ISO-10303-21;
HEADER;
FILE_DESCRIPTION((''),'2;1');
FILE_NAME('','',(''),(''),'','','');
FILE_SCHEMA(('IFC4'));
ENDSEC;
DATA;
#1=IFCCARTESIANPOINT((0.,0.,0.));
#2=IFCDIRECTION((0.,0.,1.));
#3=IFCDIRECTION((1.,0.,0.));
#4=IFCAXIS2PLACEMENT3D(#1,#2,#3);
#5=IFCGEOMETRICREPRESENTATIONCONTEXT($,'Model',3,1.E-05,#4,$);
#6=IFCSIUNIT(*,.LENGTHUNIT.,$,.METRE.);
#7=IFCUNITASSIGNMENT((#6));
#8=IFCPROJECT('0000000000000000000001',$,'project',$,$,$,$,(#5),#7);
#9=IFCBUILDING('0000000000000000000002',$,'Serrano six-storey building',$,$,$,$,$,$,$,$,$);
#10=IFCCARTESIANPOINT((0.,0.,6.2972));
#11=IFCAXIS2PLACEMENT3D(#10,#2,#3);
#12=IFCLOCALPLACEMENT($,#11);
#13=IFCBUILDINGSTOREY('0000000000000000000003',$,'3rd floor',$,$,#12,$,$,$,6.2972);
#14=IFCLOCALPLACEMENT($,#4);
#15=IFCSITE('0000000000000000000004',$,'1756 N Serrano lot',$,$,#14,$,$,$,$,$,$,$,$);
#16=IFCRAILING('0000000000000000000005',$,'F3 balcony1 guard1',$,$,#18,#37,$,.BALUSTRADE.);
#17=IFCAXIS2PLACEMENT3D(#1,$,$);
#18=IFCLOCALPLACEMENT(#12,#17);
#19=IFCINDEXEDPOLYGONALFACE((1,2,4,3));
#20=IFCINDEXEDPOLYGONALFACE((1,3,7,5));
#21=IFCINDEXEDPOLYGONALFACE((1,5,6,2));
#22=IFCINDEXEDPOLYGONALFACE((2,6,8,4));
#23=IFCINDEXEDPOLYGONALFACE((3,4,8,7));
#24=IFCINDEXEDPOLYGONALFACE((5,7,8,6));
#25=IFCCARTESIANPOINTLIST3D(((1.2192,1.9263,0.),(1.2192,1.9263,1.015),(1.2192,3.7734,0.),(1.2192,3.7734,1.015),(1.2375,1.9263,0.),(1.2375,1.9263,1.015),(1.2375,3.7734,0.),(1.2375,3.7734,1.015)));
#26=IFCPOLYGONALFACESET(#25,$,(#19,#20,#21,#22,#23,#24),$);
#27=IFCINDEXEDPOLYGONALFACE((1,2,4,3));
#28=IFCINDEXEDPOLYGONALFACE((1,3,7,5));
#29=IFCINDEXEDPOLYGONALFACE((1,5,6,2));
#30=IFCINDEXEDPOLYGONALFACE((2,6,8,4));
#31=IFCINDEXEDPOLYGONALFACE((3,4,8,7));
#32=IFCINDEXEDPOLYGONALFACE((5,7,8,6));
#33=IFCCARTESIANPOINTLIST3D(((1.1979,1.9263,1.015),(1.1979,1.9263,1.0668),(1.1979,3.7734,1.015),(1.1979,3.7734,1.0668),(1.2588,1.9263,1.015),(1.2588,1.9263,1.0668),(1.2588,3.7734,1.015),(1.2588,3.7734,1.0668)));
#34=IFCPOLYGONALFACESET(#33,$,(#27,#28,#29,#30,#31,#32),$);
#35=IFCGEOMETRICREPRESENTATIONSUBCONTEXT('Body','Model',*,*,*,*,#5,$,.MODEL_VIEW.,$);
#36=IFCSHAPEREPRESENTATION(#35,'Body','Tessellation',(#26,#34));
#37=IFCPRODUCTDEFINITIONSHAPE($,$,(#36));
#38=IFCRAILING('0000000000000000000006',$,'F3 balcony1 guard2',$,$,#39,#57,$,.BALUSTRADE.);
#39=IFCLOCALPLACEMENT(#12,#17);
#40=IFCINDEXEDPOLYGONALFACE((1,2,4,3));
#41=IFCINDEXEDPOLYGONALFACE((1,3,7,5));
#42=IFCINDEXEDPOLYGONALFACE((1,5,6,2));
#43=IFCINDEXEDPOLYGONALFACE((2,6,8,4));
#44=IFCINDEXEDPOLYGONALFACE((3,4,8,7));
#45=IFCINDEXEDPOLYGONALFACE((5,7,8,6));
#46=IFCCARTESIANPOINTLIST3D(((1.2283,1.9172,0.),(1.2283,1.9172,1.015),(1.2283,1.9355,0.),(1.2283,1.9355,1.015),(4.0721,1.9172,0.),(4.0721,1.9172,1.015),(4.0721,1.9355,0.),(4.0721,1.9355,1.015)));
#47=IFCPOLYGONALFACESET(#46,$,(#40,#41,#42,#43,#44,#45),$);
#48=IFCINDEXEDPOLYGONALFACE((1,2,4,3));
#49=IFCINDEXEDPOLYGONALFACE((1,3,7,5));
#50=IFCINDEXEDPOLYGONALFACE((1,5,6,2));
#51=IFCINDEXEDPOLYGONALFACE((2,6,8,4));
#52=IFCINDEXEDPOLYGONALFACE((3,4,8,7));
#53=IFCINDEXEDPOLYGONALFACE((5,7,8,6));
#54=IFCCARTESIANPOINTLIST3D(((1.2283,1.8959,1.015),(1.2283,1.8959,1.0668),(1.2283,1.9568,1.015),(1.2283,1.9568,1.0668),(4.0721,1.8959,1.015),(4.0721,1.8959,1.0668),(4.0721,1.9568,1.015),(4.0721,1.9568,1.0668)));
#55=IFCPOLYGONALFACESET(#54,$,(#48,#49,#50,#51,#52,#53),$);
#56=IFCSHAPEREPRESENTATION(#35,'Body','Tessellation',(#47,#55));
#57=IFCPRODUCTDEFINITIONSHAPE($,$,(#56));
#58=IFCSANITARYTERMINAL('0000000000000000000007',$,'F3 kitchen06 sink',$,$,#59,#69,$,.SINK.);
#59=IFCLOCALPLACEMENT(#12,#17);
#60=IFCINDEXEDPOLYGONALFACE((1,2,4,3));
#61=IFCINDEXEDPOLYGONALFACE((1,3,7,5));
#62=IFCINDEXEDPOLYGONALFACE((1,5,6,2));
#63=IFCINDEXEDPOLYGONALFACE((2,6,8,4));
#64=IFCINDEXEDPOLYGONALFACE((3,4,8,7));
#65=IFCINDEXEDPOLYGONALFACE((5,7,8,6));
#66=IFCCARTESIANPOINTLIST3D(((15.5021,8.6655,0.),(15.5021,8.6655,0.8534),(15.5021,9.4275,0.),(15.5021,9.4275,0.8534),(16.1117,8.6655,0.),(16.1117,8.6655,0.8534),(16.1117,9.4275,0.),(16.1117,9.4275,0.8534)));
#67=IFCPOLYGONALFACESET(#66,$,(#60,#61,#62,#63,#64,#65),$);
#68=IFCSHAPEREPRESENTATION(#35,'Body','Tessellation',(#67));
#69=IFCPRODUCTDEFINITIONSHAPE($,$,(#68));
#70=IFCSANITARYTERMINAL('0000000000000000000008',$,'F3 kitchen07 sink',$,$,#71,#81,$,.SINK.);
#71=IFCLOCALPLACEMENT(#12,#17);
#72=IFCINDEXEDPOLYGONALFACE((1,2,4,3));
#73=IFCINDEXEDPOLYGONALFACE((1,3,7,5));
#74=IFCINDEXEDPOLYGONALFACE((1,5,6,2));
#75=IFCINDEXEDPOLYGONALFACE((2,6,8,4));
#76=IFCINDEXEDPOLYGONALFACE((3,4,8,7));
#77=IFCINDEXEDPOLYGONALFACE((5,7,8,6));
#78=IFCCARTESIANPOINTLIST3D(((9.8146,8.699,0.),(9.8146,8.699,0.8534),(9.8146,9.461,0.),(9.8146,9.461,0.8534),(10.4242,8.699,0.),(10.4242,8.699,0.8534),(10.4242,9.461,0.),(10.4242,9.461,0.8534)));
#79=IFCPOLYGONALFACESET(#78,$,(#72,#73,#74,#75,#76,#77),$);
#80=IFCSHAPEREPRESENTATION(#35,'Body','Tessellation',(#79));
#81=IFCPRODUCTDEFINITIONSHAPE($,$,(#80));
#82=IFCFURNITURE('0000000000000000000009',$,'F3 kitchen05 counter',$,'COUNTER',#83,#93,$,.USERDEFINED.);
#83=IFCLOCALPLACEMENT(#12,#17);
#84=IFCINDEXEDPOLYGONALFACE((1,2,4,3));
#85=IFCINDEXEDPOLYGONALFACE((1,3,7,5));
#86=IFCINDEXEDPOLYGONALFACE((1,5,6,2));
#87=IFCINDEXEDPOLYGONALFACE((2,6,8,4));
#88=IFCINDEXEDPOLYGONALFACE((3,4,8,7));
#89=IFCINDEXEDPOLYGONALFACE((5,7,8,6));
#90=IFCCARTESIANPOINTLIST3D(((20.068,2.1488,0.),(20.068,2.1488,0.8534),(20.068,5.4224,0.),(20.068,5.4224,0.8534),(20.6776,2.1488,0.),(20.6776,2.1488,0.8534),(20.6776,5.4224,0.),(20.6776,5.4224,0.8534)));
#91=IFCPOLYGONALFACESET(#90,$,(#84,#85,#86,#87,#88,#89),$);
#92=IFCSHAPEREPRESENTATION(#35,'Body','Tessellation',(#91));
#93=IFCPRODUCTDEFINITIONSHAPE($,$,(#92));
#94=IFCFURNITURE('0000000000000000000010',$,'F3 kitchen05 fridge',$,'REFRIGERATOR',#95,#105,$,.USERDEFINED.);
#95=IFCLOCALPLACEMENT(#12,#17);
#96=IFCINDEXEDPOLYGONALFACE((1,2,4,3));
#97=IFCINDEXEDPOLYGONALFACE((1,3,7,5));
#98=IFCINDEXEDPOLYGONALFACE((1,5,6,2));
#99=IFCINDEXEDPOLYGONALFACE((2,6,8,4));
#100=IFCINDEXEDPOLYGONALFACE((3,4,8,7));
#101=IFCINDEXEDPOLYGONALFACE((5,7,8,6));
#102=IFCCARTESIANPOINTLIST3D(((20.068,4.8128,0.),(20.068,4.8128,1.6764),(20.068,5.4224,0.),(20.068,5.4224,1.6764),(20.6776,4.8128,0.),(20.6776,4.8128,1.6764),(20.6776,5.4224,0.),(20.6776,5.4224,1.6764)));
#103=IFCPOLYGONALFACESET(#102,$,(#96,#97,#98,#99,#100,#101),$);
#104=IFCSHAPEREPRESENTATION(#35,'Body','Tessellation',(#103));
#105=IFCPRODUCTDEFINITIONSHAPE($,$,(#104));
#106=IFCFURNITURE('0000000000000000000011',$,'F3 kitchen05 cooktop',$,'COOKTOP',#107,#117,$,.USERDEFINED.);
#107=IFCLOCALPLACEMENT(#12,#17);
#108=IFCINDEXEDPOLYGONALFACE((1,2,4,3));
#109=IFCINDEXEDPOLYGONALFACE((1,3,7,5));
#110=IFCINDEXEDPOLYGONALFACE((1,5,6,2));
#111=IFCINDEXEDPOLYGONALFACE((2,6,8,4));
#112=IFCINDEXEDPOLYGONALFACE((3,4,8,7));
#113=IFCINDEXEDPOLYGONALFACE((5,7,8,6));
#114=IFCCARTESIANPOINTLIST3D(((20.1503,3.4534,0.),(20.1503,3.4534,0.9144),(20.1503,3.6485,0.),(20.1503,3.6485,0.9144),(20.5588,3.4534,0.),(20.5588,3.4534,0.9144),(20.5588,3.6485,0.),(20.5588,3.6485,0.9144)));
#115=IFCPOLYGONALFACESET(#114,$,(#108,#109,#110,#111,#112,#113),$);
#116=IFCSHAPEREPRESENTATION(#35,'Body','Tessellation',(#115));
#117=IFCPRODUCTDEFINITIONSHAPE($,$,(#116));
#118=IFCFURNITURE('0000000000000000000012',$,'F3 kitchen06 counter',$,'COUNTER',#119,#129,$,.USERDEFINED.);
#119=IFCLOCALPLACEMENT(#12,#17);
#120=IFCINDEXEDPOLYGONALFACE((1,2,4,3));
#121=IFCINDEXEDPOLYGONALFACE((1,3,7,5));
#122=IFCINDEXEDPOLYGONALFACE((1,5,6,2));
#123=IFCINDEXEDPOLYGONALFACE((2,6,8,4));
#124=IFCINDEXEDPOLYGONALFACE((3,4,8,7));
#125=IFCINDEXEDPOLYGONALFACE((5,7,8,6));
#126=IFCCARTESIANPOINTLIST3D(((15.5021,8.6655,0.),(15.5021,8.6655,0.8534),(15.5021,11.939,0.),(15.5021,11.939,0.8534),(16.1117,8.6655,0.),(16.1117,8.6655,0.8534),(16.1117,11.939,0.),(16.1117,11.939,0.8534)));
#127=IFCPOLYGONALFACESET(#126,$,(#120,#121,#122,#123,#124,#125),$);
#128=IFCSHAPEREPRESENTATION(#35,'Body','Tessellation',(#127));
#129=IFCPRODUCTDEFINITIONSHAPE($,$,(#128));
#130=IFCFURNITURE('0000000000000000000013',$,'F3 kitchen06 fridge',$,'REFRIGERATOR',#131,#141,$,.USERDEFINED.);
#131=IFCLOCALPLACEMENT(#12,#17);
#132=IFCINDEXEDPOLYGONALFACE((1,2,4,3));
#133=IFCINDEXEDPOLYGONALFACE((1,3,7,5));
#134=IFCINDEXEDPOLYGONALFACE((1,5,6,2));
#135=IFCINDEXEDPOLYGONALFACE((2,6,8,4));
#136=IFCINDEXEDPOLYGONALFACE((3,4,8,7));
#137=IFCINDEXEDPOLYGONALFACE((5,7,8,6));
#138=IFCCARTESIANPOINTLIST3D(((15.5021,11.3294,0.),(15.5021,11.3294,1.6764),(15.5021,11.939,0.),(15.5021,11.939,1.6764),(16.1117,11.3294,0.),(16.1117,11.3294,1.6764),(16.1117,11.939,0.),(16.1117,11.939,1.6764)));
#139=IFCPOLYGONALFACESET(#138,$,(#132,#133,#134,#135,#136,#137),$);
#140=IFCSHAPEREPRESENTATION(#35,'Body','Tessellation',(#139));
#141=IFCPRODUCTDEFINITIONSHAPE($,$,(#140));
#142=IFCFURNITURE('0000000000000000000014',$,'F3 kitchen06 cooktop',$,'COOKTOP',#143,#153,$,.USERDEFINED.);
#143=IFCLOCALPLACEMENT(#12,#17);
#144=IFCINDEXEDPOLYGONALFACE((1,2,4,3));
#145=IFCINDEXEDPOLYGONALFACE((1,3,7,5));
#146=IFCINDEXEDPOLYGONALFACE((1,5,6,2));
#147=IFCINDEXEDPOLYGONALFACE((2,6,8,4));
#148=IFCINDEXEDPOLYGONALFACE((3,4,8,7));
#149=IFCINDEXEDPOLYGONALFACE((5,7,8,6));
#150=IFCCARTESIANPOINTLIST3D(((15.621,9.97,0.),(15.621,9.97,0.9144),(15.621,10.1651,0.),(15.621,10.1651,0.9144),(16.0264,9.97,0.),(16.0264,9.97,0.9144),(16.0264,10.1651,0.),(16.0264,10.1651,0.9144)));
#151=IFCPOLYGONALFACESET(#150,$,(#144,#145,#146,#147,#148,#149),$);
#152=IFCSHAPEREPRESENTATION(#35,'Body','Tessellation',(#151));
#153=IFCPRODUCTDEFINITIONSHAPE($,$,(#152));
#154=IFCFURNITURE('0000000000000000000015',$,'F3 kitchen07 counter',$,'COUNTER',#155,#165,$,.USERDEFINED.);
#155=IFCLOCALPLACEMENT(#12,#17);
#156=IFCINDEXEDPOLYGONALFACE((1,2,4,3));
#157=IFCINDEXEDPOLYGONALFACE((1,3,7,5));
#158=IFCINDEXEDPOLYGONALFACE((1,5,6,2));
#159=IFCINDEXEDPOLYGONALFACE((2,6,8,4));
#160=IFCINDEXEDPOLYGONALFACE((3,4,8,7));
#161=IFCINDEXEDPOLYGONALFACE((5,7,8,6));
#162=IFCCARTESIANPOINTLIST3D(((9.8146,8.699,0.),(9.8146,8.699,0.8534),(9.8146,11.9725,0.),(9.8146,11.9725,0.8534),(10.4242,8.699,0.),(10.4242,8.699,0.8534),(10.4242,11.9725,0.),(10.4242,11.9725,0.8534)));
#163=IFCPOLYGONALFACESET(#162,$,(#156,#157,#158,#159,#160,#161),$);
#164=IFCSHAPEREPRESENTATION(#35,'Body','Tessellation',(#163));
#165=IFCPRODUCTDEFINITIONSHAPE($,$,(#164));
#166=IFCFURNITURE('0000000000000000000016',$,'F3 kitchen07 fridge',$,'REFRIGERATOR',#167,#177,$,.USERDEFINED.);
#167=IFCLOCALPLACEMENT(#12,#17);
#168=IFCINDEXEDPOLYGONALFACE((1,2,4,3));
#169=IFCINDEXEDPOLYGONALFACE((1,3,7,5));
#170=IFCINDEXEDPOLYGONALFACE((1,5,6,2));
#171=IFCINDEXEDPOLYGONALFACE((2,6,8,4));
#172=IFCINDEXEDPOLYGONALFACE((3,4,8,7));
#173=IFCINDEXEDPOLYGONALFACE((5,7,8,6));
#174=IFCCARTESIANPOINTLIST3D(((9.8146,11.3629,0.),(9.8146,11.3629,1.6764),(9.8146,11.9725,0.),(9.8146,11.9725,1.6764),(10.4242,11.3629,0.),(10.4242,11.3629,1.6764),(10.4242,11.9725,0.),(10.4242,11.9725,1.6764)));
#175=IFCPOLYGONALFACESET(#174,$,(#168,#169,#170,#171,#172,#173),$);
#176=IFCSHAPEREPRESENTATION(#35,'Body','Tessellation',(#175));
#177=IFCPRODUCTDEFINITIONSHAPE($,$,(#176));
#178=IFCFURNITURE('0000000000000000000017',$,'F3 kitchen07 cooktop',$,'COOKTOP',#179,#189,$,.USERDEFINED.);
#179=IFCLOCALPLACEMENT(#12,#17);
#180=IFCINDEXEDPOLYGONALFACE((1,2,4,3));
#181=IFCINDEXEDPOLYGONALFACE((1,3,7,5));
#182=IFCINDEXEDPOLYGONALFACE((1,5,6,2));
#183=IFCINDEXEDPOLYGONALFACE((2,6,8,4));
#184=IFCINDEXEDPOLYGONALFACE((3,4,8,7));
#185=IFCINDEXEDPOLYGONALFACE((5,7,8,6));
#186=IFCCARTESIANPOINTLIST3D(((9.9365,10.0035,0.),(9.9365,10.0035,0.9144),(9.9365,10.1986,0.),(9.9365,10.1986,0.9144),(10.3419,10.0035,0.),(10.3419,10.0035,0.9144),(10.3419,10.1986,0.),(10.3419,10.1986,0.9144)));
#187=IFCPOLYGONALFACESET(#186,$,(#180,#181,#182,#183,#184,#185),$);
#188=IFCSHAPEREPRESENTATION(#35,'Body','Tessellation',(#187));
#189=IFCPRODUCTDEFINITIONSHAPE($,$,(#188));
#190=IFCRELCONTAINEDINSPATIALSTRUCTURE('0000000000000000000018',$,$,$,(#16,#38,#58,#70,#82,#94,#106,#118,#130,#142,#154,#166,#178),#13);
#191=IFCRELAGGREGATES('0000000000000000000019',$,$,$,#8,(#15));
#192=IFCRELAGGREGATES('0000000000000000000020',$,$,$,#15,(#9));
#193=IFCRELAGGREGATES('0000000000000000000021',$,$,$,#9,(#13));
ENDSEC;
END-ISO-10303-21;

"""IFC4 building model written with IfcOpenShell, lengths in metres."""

from ifc_helpers import new_model, si_unit, frame, origin_with_axes, place, context, subcontext, project, spatial, polyline, outline, extrude, element, save


model = new_model("IFC4")

# Units and contexts
model_context = context("Model", 3, precision=1e-05, world=origin_with_axes())
body_context = subcontext(model_context, "Body", "Model", "MODEL_VIEW")
ifc_project = project(units=[si_unit("LENGTHUNIT", "METRE")], contexts=[model_context])

# Site, building, storey
site_placement = place(None, origin_with_axes())
site = spatial("IfcSite", under=ifc_project, at=site_placement, Name="1756 N Serrano lot")
building = spatial("IfcBuilding", under=site, Name="Serrano six-storey building")
storey_placement = place(None, frame((0.0, 0.0, 6.2972), z_axis=(0.0, 0.0, 1.0), x_axis=(1.0, 0.0, 0.0)))
storey = spatial("IfcBuildingStorey", under=building, at=storey_placement, Name="3rd floor", Elevation=6.2972)

# Railings
railing_1_placement = place(storey_placement, frame((0.0, 0.0, -6.2972), z_axis=(0.0, 0.0, 1.0), x_axis=(1.0, 0.0, 0.0)))
element("IfcRailing", 1, at=railing_1_placement, inside=storey, Name="F3 balcony1 guard1", PredefinedType="BALUSTRADE", context=body_context, shape_type="SweptSolid", body=[
    extrude(outline(polyline([(1.2192, 3.7734), (1.2375, 3.7734), (1.2375, 1.9263), (1.2192, 1.9263), (1.2192, 3.7734)])), frame((0.0, 0.0, 6.2972)), (0.0, 0.0, 1.0), 1.015),
    extrude(outline(polyline([(1.1979, 3.7734), (1.2588, 3.7734), (1.2588, 1.9263), (1.1979, 1.9263), (1.1979, 3.7734)])), frame((0.0, 0.0, 7.3122)), (0.0, 0.0, 1.0), 0.0518),
])
railing_2_placement = place(storey_placement, frame((0.0, 0.0, -6.2972), z_axis=(0.0, 0.0, 1.0), x_axis=(1.0, 0.0, 0.0)))
element("IfcRailing", 2, at=railing_2_placement, inside=storey, Name="F3 balcony1 guard2", PredefinedType="BALUSTRADE", context=body_context, shape_type="SweptSolid", body=[
    extrude(outline(polyline([(1.2283, 1.9172), (1.2283, 1.9355), (4.0721, 1.9355), (4.0721, 1.9172), (1.2283, 1.9172)])), frame((0.0, 0.0, 6.2972)), (0.0, 0.0, 1.0), 1.015),
    extrude(outline(polyline([(1.2283, 1.8959), (1.2283, 1.9568), (4.0721, 1.9568), (4.0721, 1.8959), (1.2283, 1.8959)])), frame((0.0, 0.0, 7.3122)), (0.0, 0.0, 1.0), 0.0518),
])

# Sanitary terminals
sanitary_terminal_1_placement = place(storey_placement, frame((0.0, 0.0, -6.2972), z_axis=(0.0, 0.0, 1.0), x_axis=(1.0, 0.0, 0.0)))
element("IfcSanitaryTerminal", 3, at=sanitary_terminal_1_placement, inside=storey, Name="F3 kitchen06 sink", PredefinedType="SINK", context=body_context, shape_type="SweptSolid", body=[
    extrude(outline(polyline([(16.1117, 8.6655), (16.1117, 9.4275), (15.5021, 9.4275), (15.5021, 8.6655), (16.1117, 8.6655)])), frame((0.0, 0.0, 6.2972)), (0.0, 0.0, 1.0), 0.8534),
])
sanitary_terminal_2_placement = place(storey_placement, frame((0.0, 0.0, -6.2972), z_axis=(0.0, 0.0, 1.0), x_axis=(1.0, 0.0, 0.0)))
element("IfcSanitaryTerminal", 4, at=sanitary_terminal_2_placement, inside=storey, Name="F3 kitchen07 sink", PredefinedType="SINK", context=body_context, shape_type="SweptSolid", body=[
    extrude(outline(polyline([(10.4242, 8.699), (10.4242, 9.461), (9.8146, 9.461), (9.8146, 8.699), (10.4242, 8.699)])), frame((0.0, 0.0, 6.2972)), (0.0, 0.0, 1.0), 0.8534),
])

# Furniture
furniture_1_placement = place(storey_placement, frame((0.0, 0.0, -6.2972), z_axis=(0.0, 0.0, 1.0), x_axis=(1.0, 0.0, 0.0)))
element("IfcFurniture", 5, at=furniture_1_placement, inside=storey, Name="F3 kitchen05 counter", ObjectType="COUNTER", PredefinedType="USERDEFINED", context=body_context, shape_type="SweptSolid", body=[
    extrude(outline(polyline([(20.6776, 2.1488), (20.6776, 5.4224), (20.068, 5.4224), (20.068, 2.1488), (20.6776, 2.1488)])), frame((0.0, 0.0, 6.2972)), (0.0, 0.0, 1.0), 0.8534),
])
furniture_2_placement = place(storey_placement, frame((0.0, 0.0, -6.2972), z_axis=(0.0, 0.0, 1.0), x_axis=(1.0, 0.0, 0.0)))
element("IfcFurniture", 6, at=furniture_2_placement, inside=storey, Name="F3 kitchen05 fridge", ObjectType="REFRIGERATOR", PredefinedType="USERDEFINED", context=body_context, shape_type="SweptSolid", body=[
    extrude(outline(polyline([(20.6776, 4.8128), (20.6776, 5.4224), (20.068, 5.4224), (20.068, 4.8128), (20.6776, 4.8128)])), frame((0.0, 0.0, 6.2972)), (0.0, 0.0, 1.0), 1.6764),
])
furniture_3_placement = place(storey_placement, frame((0.0, 0.0, -6.2972), z_axis=(0.0, 0.0, 1.0), x_axis=(1.0, 0.0, 0.0)))
element("IfcFurniture", 7, at=furniture_3_placement, inside=storey, Name="F3 kitchen05 cooktop", ObjectType="COOKTOP", PredefinedType="USERDEFINED", context=body_context, shape_type="SweptSolid", body=[
    extrude(outline(polyline([(20.5588, 3.4534), (20.5588, 3.6485), (20.1503, 3.6485), (20.1503, 3.4534), (20.5588, 3.4534)])), frame((0.0, 0.0, 6.2972)), (0.0, 0.0, 1.0), 0.9144),
])
furniture_4_placement = place(storey_placement, frame((0.0, 0.0, -6.2972), z_axis=(0.0, 0.0, 1.0), x_axis=(1.0, 0.0, 0.0)))
element("IfcFurniture", 8, at=furniture_4_placement, inside=storey, Name="F3 kitchen06 counter", ObjectType="COUNTER", PredefinedType="USERDEFINED", context=body_context, shape_type="SweptSolid", body=[
    extrude(outline(polyline([(16.1117, 8.6655), (16.1117, 11.939), (15.5021, 11.939), (15.5021, 8.6655), (16.1117, 8.6655)])), frame((0.0, 0.0, 6.2972)), (0.0, 0.0, 1.0), 0.8534),
])
furniture_5_placement = place(storey_placement, frame((0.0, 0.0, -6.2972), z_axis=(0.0, 0.0, 1.0), x_axis=(1.0, 0.0, 0.0)))
element("IfcFurniture", 9, at=furniture_5_placement, inside=storey, Name="F3 kitchen06 fridge", ObjectType="REFRIGERATOR", PredefinedType="USERDEFINED", context=body_context, shape_type="SweptSolid", body=[
    extrude(outline(polyline([(16.1117, 11.3294), (16.1117, 11.939), (15.5021, 11.939), (15.5021, 11.3294), (16.1117, 11.3294)])), frame((0.0, 0.0, 6.2972)), (0.0, 0.0, 1.0), 1.6764),
])
furniture_6_placement = place(storey_placement, frame((0.0, 0.0, -6.2972), z_axis=(0.0, 0.0, 1.0), x_axis=(1.0, 0.0, 0.0)))
element("IfcFurniture", 10, at=furniture_6_placement, inside=storey, Name="F3 kitchen06 cooktop", ObjectType="COOKTOP", PredefinedType="USERDEFINED", context=body_context, shape_type="SweptSolid", body=[
    extrude(outline(polyline([(16.0264, 9.97), (16.0264, 10.1651), (15.621, 10.1651), (15.621, 9.97), (16.0264, 9.97)])), frame((0.0, 0.0, 6.2972)), (0.0, 0.0, 1.0), 0.9144),
])
furniture_7_placement = place(storey_placement, frame((0.0, 0.0, -6.2972), z_axis=(0.0, 0.0, 1.0), x_axis=(1.0, 0.0, 0.0)))
element("IfcFurniture", 11, at=furniture_7_placement, inside=storey, Name="F3 kitchen07 counter", ObjectType="COUNTER", PredefinedType="USERDEFINED", context=body_context, shape_type="SweptSolid", body=[
    extrude(outline(polyline([(10.4242, 8.699), (10.4242, 11.9725), (9.8146, 11.9725), (9.8146, 8.699), (10.4242, 8.699)])), frame((0.0, 0.0, 6.2972)), (0.0, 0.0, 1.0), 0.8534),
])
furniture_8_placement = place(storey_placement, frame((0.0, 0.0, -6.2972), z_axis=(0.0, 0.0, 1.0), x_axis=(1.0, 0.0, 0.0)))
element("IfcFurniture", 12, at=furniture_8_placement, inside=storey, Name="F3 kitchen07 fridge", ObjectType="REFRIGERATOR", PredefinedType="USERDEFINED", context=body_context, shape_type="SweptSolid", body=[
    extrude(outline(polyline([(10.4242, 11.3629), (10.4242, 11.9725), (9.8146, 11.9725), (9.8146, 11.3629), (10.4242, 11.3629)])), frame((0.0, 0.0, 6.2972)), (0.0, 0.0, 1.0), 1.6764),
])
furniture_9_placement = place(storey_placement, frame((0.0, 0.0, -6.2972), z_axis=(0.0, 0.0, 1.0), x_axis=(1.0, 0.0, 0.0)))
element("IfcFurniture", 13, at=furniture_9_placement, inside=storey, Name="F3 kitchen07 cooktop", ObjectType="COOKTOP", PredefinedType="USERDEFINED", context=body_context, shape_type="SweptSolid", body=[
    extrude(outline(polyline([(10.3419, 10.0035), (10.3419, 10.1986), (9.9365, 10.1986), (9.9365, 10.0035), (10.3419, 10.0035)])), frame((0.0, 0.0, 6.2972)), (0.0, 0.0, 1.0), 0.9144),
])

save(model, "model.ifc")
